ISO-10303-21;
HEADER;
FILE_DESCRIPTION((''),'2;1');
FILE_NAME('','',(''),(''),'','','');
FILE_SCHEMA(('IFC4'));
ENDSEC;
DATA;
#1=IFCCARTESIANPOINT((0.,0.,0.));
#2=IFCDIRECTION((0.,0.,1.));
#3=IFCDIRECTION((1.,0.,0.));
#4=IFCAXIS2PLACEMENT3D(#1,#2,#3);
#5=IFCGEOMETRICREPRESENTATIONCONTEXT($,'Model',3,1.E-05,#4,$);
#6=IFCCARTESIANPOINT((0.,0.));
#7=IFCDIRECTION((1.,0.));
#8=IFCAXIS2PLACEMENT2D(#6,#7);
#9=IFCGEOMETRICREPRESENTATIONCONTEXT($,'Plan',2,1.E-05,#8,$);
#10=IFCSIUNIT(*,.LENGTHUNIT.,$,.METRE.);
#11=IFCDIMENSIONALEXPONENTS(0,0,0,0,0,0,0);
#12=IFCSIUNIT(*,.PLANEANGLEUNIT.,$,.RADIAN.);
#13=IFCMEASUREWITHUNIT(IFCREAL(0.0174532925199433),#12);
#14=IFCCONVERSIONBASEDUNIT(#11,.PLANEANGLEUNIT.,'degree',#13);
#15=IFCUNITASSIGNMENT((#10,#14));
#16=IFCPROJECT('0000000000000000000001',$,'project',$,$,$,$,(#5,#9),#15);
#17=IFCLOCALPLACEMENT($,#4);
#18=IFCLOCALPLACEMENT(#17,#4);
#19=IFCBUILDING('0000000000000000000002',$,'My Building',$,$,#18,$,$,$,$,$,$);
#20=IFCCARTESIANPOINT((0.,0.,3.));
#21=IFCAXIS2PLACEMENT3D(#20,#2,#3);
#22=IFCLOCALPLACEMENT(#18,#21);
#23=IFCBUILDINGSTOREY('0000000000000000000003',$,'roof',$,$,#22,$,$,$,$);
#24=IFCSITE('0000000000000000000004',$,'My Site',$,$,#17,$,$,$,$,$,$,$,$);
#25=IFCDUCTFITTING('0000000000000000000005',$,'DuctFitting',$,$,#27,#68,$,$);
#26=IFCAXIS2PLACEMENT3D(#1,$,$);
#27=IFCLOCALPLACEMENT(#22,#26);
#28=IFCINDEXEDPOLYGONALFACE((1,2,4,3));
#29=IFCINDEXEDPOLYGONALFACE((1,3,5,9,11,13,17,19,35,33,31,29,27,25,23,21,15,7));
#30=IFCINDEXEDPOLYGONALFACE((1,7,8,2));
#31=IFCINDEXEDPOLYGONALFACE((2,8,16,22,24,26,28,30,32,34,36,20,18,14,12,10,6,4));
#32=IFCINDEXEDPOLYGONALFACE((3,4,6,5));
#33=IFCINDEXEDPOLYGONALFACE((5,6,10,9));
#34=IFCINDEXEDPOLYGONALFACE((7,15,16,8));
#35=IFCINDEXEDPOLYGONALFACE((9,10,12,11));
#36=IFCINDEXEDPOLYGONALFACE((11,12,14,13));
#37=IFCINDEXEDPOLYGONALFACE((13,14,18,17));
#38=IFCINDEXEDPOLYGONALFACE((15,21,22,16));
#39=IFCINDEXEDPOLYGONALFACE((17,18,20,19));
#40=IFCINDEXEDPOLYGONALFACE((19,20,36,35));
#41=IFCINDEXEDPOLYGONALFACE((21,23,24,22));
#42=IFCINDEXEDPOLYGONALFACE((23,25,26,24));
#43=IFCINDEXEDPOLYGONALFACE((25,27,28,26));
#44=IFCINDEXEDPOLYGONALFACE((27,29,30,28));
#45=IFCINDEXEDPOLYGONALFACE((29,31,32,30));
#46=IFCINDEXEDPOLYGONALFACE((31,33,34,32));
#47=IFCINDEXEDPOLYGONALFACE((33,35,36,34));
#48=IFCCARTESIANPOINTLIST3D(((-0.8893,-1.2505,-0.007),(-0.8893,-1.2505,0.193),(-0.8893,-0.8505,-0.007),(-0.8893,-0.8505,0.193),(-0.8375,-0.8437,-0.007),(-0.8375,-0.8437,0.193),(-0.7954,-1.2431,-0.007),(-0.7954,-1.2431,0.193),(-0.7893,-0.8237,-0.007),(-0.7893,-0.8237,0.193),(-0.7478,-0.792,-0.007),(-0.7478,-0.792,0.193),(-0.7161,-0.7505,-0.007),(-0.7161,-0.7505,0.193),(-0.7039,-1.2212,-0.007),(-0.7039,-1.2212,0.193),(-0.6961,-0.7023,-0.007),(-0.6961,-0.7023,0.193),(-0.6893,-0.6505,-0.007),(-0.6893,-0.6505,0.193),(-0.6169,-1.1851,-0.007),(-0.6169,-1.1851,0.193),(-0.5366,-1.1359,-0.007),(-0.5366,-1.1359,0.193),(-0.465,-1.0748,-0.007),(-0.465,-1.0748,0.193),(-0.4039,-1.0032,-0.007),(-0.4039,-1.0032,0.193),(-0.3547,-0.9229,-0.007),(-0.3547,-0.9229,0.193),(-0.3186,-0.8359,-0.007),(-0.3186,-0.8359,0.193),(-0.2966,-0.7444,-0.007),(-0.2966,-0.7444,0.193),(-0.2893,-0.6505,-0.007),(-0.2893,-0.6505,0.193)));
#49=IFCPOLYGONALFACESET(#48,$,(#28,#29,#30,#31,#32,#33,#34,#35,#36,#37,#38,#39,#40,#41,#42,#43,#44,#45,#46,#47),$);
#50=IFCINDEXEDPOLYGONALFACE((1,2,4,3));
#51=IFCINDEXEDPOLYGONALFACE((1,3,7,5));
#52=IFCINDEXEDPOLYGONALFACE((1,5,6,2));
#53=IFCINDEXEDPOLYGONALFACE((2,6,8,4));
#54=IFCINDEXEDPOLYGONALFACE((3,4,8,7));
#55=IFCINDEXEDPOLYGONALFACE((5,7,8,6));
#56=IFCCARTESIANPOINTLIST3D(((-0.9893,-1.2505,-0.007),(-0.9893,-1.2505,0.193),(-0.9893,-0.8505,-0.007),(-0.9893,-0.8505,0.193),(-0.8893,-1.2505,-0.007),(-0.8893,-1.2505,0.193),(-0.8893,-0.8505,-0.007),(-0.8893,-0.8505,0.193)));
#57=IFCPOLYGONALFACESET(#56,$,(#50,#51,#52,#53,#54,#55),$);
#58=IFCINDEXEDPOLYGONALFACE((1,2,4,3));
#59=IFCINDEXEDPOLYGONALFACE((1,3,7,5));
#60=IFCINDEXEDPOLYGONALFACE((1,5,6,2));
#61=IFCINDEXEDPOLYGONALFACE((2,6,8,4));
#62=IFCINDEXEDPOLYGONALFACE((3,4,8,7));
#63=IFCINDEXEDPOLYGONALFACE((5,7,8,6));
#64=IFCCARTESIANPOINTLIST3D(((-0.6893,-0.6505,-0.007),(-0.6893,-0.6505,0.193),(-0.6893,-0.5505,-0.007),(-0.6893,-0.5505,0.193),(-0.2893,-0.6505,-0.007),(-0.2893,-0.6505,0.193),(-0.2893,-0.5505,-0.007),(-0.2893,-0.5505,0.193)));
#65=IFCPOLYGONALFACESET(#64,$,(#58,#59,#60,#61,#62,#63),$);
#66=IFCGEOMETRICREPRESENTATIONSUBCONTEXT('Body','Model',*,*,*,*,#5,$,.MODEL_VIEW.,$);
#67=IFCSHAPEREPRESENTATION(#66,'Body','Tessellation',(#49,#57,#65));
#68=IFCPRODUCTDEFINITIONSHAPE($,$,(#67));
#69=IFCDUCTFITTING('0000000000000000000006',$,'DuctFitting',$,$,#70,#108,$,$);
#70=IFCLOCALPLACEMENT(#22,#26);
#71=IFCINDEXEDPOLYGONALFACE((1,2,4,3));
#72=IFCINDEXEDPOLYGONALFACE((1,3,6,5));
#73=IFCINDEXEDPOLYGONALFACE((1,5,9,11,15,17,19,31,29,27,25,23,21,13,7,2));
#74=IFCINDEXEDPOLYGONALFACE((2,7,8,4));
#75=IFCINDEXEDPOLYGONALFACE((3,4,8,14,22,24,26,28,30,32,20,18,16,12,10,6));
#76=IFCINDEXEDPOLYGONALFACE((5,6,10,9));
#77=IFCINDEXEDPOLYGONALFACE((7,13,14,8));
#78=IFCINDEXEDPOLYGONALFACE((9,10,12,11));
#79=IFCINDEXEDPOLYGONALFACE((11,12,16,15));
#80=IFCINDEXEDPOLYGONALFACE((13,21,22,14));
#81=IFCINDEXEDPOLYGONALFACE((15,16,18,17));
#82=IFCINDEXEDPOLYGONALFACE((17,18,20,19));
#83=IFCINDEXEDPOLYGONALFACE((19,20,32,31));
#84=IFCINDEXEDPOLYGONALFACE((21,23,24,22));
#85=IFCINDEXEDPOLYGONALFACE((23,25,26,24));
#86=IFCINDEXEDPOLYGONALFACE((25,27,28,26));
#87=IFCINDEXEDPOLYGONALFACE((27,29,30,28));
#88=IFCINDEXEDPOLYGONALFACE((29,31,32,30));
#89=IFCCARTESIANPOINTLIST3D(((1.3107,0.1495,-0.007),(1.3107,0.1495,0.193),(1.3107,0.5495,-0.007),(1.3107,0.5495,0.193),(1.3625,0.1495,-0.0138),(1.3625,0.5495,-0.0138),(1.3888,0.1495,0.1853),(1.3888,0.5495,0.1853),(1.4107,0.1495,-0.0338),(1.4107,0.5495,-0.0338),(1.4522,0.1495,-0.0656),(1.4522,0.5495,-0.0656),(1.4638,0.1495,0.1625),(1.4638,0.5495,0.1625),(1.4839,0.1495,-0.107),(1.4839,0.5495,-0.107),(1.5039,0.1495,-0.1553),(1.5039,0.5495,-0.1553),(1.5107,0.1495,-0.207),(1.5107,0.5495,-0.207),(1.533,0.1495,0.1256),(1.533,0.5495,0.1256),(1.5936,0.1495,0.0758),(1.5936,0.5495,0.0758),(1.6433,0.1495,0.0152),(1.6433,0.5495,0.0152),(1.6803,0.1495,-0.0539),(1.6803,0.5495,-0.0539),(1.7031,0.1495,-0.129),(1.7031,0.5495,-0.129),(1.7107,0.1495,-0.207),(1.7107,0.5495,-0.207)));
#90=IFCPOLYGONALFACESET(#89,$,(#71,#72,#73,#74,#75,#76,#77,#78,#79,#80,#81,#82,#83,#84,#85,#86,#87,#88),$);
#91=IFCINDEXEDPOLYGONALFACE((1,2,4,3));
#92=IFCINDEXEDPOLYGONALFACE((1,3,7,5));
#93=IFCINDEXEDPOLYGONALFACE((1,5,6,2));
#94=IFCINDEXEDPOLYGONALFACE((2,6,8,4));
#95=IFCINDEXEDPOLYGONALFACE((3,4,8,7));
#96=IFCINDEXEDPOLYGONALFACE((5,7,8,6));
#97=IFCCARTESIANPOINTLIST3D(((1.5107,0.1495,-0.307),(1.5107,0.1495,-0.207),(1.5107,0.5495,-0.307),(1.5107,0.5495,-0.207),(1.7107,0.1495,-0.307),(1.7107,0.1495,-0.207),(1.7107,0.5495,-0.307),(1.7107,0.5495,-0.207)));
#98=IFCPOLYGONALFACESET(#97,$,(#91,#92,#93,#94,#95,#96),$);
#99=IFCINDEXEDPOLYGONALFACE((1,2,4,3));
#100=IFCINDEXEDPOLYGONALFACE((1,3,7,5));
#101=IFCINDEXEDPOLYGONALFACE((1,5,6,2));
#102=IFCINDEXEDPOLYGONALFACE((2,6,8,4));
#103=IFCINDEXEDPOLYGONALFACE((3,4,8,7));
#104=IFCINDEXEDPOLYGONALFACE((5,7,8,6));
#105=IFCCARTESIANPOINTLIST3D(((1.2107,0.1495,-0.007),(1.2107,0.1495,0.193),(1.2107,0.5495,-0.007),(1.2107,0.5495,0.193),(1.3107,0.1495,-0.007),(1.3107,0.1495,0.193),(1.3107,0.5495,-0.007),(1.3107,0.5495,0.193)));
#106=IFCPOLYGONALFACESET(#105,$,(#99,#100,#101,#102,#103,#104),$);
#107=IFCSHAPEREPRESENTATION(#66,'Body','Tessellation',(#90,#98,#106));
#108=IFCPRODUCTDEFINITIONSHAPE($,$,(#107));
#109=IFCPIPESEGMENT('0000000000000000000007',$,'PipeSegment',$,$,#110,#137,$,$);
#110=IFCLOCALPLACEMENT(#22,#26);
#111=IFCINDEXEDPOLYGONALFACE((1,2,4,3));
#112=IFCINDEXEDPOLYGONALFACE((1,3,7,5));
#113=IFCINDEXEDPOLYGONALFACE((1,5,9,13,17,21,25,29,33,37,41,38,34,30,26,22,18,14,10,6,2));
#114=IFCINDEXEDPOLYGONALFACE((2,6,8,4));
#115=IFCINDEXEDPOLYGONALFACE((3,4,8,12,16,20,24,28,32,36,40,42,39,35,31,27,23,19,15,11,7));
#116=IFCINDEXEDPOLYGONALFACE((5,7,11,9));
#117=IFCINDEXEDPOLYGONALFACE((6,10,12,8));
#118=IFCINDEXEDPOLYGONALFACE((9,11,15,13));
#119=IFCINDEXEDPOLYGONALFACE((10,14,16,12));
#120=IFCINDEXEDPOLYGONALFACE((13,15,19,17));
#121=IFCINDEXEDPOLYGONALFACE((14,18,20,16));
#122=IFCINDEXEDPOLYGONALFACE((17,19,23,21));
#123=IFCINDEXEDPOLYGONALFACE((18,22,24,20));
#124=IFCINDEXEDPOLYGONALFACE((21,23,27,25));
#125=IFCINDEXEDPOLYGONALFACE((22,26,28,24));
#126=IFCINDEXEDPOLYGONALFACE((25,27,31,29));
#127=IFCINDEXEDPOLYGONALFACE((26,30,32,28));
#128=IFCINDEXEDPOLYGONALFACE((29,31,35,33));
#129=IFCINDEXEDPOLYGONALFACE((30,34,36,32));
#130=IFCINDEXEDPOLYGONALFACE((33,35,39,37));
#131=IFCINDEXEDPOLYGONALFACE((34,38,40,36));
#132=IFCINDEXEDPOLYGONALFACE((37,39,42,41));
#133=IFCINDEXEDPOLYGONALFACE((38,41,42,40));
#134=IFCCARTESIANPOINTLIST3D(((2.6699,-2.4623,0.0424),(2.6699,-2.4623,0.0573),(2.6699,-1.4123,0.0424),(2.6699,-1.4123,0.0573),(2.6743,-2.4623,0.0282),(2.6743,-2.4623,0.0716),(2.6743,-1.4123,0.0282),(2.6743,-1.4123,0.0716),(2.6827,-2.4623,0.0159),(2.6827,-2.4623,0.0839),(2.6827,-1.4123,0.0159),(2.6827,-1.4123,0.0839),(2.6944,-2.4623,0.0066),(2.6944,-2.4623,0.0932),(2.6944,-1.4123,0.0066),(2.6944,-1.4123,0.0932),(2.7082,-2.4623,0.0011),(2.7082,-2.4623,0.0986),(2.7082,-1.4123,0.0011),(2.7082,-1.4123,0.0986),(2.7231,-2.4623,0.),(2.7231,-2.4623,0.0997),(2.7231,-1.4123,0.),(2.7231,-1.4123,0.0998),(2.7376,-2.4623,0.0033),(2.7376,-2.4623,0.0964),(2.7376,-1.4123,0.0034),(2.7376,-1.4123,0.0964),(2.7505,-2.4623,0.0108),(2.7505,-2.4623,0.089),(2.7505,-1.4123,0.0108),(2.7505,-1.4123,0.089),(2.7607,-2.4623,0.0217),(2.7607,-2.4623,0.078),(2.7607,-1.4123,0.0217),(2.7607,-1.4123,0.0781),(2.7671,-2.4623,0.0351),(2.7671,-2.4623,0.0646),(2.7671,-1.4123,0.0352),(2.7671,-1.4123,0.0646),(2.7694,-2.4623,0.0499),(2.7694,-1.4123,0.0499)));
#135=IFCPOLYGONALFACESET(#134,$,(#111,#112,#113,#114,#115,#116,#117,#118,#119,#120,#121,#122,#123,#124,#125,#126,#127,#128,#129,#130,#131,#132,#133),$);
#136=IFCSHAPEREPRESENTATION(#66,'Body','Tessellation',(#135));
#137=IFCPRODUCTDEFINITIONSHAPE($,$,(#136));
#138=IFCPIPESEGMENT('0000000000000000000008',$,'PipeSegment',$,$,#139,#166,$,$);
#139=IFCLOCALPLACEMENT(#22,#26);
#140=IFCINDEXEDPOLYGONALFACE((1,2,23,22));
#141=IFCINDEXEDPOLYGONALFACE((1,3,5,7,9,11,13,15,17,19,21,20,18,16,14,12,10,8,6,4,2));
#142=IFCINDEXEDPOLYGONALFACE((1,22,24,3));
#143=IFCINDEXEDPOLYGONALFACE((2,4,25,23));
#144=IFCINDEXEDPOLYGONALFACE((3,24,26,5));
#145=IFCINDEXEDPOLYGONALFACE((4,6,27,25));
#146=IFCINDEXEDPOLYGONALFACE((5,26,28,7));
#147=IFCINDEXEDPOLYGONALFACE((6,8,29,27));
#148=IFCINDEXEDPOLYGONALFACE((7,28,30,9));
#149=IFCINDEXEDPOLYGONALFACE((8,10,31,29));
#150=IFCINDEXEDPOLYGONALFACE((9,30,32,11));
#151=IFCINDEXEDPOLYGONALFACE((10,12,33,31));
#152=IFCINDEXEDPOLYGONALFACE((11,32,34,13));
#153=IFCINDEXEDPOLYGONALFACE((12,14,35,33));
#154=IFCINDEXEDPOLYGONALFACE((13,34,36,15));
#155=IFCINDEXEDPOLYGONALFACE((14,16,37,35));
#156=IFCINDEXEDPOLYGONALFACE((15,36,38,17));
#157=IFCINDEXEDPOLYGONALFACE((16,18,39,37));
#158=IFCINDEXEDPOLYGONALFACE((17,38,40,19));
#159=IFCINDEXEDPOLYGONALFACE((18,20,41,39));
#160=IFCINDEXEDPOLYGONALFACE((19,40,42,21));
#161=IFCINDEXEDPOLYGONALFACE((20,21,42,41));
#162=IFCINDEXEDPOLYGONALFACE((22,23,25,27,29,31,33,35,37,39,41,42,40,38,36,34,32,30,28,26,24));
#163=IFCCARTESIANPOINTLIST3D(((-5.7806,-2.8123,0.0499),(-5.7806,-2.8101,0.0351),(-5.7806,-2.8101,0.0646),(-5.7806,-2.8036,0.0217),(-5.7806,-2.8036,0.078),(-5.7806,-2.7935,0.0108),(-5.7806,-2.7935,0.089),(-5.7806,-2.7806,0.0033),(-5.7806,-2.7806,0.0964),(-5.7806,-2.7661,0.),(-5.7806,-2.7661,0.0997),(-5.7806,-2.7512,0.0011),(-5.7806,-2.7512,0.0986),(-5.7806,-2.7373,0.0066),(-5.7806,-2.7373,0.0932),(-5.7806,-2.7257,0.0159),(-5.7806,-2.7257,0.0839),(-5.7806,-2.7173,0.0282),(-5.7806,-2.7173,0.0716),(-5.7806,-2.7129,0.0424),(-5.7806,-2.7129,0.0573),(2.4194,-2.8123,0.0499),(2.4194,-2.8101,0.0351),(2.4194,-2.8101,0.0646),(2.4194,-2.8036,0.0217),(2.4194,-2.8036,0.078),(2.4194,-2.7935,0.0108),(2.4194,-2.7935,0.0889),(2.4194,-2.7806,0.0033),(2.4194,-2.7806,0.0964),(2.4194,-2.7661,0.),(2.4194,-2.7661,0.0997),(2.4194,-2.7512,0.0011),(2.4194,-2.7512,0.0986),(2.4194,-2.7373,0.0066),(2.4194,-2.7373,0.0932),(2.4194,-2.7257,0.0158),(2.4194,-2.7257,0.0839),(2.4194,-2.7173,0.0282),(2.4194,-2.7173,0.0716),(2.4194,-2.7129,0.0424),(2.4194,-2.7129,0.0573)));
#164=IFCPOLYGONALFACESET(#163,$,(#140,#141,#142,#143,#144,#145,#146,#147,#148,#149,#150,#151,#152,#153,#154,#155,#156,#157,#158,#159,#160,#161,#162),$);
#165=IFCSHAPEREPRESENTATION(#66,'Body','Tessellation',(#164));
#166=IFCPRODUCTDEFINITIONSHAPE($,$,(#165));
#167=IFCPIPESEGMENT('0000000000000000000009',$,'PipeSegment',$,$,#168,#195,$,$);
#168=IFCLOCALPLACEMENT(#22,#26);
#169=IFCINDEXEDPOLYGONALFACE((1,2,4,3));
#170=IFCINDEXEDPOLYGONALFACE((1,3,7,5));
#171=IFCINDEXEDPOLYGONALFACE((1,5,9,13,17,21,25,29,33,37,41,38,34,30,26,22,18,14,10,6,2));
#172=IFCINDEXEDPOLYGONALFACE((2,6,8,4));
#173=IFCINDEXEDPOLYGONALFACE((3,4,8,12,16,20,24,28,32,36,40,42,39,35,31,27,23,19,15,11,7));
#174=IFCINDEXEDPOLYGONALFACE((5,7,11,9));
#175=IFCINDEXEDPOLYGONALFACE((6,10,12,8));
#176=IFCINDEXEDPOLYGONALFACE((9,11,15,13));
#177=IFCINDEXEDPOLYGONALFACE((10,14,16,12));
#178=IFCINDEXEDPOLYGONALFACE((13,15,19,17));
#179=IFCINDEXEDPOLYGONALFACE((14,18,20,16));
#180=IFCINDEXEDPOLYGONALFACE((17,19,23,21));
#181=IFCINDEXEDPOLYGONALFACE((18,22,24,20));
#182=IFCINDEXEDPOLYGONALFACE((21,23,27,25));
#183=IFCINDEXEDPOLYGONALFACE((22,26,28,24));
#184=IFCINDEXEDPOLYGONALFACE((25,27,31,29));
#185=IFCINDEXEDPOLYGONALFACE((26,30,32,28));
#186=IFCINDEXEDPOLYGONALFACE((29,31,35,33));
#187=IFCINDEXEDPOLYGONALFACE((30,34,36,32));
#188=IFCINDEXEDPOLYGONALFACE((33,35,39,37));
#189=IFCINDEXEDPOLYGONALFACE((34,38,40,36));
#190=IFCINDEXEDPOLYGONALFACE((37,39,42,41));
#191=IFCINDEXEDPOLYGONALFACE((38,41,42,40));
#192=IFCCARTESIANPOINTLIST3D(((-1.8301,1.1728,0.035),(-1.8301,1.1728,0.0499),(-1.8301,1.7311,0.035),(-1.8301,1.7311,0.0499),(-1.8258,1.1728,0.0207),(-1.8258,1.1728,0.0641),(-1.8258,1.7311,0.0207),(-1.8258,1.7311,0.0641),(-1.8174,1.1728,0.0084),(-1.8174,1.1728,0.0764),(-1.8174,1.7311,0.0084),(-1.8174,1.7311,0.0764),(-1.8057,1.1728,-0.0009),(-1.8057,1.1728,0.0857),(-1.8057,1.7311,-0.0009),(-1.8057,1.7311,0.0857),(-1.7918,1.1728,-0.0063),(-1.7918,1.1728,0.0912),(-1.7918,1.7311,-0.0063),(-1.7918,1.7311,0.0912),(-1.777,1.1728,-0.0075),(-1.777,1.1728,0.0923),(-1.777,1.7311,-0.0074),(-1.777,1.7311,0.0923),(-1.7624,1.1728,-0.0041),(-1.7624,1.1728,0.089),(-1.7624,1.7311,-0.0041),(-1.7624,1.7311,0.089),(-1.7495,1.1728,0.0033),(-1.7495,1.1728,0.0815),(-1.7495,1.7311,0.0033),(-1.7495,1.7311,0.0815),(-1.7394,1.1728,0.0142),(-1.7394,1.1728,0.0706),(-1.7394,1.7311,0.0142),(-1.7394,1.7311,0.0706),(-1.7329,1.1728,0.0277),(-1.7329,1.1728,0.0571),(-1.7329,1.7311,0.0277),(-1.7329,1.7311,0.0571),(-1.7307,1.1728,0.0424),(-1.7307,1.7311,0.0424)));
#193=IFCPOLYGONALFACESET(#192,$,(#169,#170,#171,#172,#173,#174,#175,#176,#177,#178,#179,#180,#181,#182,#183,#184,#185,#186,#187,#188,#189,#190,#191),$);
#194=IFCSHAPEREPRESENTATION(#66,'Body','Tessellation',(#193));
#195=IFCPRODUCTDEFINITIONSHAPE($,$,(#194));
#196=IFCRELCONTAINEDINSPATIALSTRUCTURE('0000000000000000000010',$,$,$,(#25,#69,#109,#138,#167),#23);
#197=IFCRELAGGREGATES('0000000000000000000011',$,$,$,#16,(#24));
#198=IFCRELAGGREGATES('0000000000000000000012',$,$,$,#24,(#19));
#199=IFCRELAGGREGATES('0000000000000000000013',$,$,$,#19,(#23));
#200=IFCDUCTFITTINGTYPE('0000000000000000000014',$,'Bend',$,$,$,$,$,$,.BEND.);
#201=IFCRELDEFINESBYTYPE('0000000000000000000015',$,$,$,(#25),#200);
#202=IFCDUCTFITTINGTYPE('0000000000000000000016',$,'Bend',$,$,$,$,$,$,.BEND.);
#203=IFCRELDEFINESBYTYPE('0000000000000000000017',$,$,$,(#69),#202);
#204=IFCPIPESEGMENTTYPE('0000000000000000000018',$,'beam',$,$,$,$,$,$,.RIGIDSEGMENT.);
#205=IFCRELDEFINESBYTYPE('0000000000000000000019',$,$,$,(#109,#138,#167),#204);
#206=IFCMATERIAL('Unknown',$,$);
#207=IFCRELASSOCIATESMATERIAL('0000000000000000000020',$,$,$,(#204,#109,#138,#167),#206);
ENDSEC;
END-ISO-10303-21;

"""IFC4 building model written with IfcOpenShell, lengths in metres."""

from ifc_helpers import new_model, entity, si_unit, converted_unit, frame, origin_with_axes, origin_2d_with_axis, place, context, subcontext, project, spatial, line, arc, indexed_curve, rectangle, circle, outline, extrude, source, transform, mapped, material, material_profile, profile_set, profile_usage, type_object, type_shapes, element, save


model = new_model("IFC4")

# Units and contexts
model_context = context("Model", 3, precision=1e-05, world=origin_with_axes())
plan_context = context("Plan", 2, precision=1e-05, world=origin_2d_with_axis())
body_context = subcontext(model_context, "Body", "Model", "MODEL_VIEW")
ifc_project = project(units=[si_unit("LENGTHUNIT", "METRE"), converted_unit("PLANEANGLEUNIT", "degree", entity("IfcReal", 0.0174532925199433), si_unit("PLANEANGLEUNIT", "RADIAN"), dimensions=[0, 0, 0, 0, 0, 0, 0])], contexts=[model_context, plan_context])

# Site, building, storey
site_placement = place(None, origin_with_axes())
site = spatial("IfcSite", under=ifc_project, at=site_placement, Name="My Site")
building_placement = place(site_placement, origin_with_axes())
building = spatial("IfcBuilding", under=site, at=building_placement, Name="My Building")
storey_placement = place(building_placement, frame((0.0, 0.0, 3.0), z_axis=(0.0, 0.0, 1.0), x_axis=(1.0, 0.0, 0.0)))
storey = spatial("IfcBuildingStorey", under=building, at=storey_placement, Name="roof")

# Shared definitions
ifc_material = material(Name="Unknown")

# Duct fittings
duct_fitting_type_1 = type_object("IfcDuctFittingType", Name="Bend", PredefinedType="BEND")
shared_shape_1 = source(origin_with_axes(), body_context, "Body", "SweptSolid", [
    extrude(outline(indexed_curve([(-0.2, 0.0), (-0.2586, 0.1414), (-0.4, 0.2), (-0.4, 0.6), (0.0243, 0.4243), (0.2, 0.0)], segments=[arc(1, 2, 3), line(3, 4), arc(4, 5, 6), line(6, 1)])), frame((0.0, -0.1, 0.1), z_axis=(0.0, -1.0, 0.0), x_axis=(1.0, 0.0, 0.0)), (0.0, 0.0, -1.0), 0.2),
    extrude(rectangle(XDim=0.4, YDim=0.2), origin_with_axes(), (0.0, 0.0, 1.0), 0.1),
    extrude(rectangle(XDim=0.4, YDim=0.2), frame((-0.4, 0.0, 0.5), z_axis=(-1.0, 0.0, 0.0), x_axis=(0.0, 0.0, -1.0)), (0.0, 0.0, 1.0), 0.1),
])
type_shapes(duct_fitting_type_1, [shared_shape_1])
for number, where, z_axis, x_axis, name in (
    (1, (-0.9893, -1.0505, 0.093), (1.0, 0.0, 0.0), (0.0, -1.0, 0.0), "DuctFitting"),
):
    element("IfcDuctFitting", number, at=place(storey_placement, frame(where, z_axis=z_axis, x_axis=x_axis)), inside=storey, type_object=duct_fitting_type_1, Name=name, context=body_context, shape_type="MappedRepresentation", body=[
        mapped(shared_shape_1, transform((0.0, 0.0, 0.0), x_axis=(1.0, 0.0, 0.0), y_axis=(0.0, 1.0, 0.0), z_axis=(0.0, 0.0, 1.0), scale=1.0)),
    ])
duct_fitting_type_2 = type_object("IfcDuctFittingType", Name="Bend", PredefinedType="BEND")
shared_shape_2 = source(origin_with_axes(), body_context, "Body", "SweptSolid", [
    extrude(outline(indexed_curve([(0.1, 0.0), (0.1586, -0.1414), (0.3, -0.2), (0.3, -0.4), (0.0172, -0.2828), (-0.1, 0.0)], segments=[arc(1, 2, 3), line(3, 4), arc(4, 5, 6), line(6, 1)])), frame((-0.2, 0.0, -0.1), z_axis=(1.0, 0.0, 0.0), x_axis=(0.0, 1.0, 0.0)), (0.0, 0.0, 1.0), 0.4),
    extrude(rectangle(XDim=0.4, YDim=0.2), origin_with_axes(), (0.0, 0.0, -1.0), 0.1),
    extrude(rectangle(XDim=0.4, YDim=0.2), frame((0.0, 0.3, -0.4), z_axis=(0.0, 1.0, 0.0), x_axis=(1.0, 0.0, 0.0)), (0.0, 0.0, 1.0), 0.1),
])
type_shapes(duct_fitting_type_2, [shared_shape_2])
duct_fitting_placement = place(storey_placement, frame((1.6107, 0.3495, -0.307), z_axis=(0.0, 0.0, -1.0), x_axis=(0.0, -1.0, 0.0)))
element("IfcDuctFitting", 2, at=duct_fitting_placement, inside=storey, type_object=duct_fitting_type_2, Name="DuctFitting", context=body_context, shape_type="MappedRepresentation", body=[
    mapped(shared_shape_2, transform((0.0, 0.0, 0.0), x_axis=(1.0, 0.0, 0.0), y_axis=(0.0, 1.0, 0.0), z_axis=(0.0, 0.0, 1.0), scale=1.0)),
])

# Pipe segments
ifc_material_profile_1 = material_profile(ifc_material, circle(Radius=0.05))
ifc_profile_set_1 = profile_set([ifc_material_profile_1])
ifc_profile_usage_1 = profile_usage(ifc_profile_set_1, cardinal=7)
pipe_segment_type = type_object("IfcPipeSegmentType", Name="beam", PredefinedType="RIGIDSEGMENT", material=ifc_profile_set_1)
pipe_segment_1_placement = place(storey_placement, frame((2.7694, -1.4123, 0.0999), z_axis=(0.0, -1.0, -0.000029), x_axis=(1.0, 0.0, 0.0)))
element("IfcPipeSegment", 3, at=pipe_segment_1_placement, inside=storey, type_object=pipe_segment_type, material=ifc_profile_usage_1, Name="PipeSegment", context=body_context, shape_type="SweptSolid", body=[
    extrude(circle(Radius=0.05), frame((-0.05, -0.05, 0.0), z_axis=(0.0, 0.0, 1.0), x_axis=(1.0, 0.0, 0.0)), (0.0, 0.0, 1.0), 1.05),
])
ifc_profile_usage_2 = profile_usage(ifc_profile_set_1, cardinal=7)
pipe_segment_2_placement = place(storey_placement, frame((2.4194, -2.8123, 0.0999), z_axis=(-1.0, 0.0, 0.0), x_axis=(0.0, -1.0, 0.0)))
element("IfcPipeSegment", 4, at=pipe_segment_2_placement, inside=storey, type_object=pipe_segment_type, material=ifc_profile_usage_2, Name="PipeSegment", context=body_context, shape_type="SweptSolid", body=[
    extrude(circle(Radius=0.05), frame((-0.05, -0.05, 0.0), z_axis=(0.0, 0.0, 1.0), x_axis=(1.0, 0.0, 0.0)), (0.0, 0.0, 1.0), 8.2),
])
ifc_profile_usage_3 = profile_usage(ifc_profile_set_1, cardinal=7)
pipe_segment_3_placement = place(storey_placement, frame((-1.7307, 1.7311, 0.0924), z_axis=(0.0, -1.0, -0.000008), x_axis=(1.0, 0.0, 0.0)))
element("IfcPipeSegment", 5, at=pipe_segment_3_placement, inside=storey, type_object=pipe_segment_type, material=ifc_profile_usage_3, Name="PipeSegment", context=body_context, shape_type="SweptSolid", body=[
    extrude(circle(Radius=0.05), frame((-0.05, -0.05, 0.0), z_axis=(0.0, 0.0, 1.0), x_axis=(1.0, 0.0, 0.0)), (0.0, 0.0, 1.0), 0.5584),
])

save(model, "model.ifc")
